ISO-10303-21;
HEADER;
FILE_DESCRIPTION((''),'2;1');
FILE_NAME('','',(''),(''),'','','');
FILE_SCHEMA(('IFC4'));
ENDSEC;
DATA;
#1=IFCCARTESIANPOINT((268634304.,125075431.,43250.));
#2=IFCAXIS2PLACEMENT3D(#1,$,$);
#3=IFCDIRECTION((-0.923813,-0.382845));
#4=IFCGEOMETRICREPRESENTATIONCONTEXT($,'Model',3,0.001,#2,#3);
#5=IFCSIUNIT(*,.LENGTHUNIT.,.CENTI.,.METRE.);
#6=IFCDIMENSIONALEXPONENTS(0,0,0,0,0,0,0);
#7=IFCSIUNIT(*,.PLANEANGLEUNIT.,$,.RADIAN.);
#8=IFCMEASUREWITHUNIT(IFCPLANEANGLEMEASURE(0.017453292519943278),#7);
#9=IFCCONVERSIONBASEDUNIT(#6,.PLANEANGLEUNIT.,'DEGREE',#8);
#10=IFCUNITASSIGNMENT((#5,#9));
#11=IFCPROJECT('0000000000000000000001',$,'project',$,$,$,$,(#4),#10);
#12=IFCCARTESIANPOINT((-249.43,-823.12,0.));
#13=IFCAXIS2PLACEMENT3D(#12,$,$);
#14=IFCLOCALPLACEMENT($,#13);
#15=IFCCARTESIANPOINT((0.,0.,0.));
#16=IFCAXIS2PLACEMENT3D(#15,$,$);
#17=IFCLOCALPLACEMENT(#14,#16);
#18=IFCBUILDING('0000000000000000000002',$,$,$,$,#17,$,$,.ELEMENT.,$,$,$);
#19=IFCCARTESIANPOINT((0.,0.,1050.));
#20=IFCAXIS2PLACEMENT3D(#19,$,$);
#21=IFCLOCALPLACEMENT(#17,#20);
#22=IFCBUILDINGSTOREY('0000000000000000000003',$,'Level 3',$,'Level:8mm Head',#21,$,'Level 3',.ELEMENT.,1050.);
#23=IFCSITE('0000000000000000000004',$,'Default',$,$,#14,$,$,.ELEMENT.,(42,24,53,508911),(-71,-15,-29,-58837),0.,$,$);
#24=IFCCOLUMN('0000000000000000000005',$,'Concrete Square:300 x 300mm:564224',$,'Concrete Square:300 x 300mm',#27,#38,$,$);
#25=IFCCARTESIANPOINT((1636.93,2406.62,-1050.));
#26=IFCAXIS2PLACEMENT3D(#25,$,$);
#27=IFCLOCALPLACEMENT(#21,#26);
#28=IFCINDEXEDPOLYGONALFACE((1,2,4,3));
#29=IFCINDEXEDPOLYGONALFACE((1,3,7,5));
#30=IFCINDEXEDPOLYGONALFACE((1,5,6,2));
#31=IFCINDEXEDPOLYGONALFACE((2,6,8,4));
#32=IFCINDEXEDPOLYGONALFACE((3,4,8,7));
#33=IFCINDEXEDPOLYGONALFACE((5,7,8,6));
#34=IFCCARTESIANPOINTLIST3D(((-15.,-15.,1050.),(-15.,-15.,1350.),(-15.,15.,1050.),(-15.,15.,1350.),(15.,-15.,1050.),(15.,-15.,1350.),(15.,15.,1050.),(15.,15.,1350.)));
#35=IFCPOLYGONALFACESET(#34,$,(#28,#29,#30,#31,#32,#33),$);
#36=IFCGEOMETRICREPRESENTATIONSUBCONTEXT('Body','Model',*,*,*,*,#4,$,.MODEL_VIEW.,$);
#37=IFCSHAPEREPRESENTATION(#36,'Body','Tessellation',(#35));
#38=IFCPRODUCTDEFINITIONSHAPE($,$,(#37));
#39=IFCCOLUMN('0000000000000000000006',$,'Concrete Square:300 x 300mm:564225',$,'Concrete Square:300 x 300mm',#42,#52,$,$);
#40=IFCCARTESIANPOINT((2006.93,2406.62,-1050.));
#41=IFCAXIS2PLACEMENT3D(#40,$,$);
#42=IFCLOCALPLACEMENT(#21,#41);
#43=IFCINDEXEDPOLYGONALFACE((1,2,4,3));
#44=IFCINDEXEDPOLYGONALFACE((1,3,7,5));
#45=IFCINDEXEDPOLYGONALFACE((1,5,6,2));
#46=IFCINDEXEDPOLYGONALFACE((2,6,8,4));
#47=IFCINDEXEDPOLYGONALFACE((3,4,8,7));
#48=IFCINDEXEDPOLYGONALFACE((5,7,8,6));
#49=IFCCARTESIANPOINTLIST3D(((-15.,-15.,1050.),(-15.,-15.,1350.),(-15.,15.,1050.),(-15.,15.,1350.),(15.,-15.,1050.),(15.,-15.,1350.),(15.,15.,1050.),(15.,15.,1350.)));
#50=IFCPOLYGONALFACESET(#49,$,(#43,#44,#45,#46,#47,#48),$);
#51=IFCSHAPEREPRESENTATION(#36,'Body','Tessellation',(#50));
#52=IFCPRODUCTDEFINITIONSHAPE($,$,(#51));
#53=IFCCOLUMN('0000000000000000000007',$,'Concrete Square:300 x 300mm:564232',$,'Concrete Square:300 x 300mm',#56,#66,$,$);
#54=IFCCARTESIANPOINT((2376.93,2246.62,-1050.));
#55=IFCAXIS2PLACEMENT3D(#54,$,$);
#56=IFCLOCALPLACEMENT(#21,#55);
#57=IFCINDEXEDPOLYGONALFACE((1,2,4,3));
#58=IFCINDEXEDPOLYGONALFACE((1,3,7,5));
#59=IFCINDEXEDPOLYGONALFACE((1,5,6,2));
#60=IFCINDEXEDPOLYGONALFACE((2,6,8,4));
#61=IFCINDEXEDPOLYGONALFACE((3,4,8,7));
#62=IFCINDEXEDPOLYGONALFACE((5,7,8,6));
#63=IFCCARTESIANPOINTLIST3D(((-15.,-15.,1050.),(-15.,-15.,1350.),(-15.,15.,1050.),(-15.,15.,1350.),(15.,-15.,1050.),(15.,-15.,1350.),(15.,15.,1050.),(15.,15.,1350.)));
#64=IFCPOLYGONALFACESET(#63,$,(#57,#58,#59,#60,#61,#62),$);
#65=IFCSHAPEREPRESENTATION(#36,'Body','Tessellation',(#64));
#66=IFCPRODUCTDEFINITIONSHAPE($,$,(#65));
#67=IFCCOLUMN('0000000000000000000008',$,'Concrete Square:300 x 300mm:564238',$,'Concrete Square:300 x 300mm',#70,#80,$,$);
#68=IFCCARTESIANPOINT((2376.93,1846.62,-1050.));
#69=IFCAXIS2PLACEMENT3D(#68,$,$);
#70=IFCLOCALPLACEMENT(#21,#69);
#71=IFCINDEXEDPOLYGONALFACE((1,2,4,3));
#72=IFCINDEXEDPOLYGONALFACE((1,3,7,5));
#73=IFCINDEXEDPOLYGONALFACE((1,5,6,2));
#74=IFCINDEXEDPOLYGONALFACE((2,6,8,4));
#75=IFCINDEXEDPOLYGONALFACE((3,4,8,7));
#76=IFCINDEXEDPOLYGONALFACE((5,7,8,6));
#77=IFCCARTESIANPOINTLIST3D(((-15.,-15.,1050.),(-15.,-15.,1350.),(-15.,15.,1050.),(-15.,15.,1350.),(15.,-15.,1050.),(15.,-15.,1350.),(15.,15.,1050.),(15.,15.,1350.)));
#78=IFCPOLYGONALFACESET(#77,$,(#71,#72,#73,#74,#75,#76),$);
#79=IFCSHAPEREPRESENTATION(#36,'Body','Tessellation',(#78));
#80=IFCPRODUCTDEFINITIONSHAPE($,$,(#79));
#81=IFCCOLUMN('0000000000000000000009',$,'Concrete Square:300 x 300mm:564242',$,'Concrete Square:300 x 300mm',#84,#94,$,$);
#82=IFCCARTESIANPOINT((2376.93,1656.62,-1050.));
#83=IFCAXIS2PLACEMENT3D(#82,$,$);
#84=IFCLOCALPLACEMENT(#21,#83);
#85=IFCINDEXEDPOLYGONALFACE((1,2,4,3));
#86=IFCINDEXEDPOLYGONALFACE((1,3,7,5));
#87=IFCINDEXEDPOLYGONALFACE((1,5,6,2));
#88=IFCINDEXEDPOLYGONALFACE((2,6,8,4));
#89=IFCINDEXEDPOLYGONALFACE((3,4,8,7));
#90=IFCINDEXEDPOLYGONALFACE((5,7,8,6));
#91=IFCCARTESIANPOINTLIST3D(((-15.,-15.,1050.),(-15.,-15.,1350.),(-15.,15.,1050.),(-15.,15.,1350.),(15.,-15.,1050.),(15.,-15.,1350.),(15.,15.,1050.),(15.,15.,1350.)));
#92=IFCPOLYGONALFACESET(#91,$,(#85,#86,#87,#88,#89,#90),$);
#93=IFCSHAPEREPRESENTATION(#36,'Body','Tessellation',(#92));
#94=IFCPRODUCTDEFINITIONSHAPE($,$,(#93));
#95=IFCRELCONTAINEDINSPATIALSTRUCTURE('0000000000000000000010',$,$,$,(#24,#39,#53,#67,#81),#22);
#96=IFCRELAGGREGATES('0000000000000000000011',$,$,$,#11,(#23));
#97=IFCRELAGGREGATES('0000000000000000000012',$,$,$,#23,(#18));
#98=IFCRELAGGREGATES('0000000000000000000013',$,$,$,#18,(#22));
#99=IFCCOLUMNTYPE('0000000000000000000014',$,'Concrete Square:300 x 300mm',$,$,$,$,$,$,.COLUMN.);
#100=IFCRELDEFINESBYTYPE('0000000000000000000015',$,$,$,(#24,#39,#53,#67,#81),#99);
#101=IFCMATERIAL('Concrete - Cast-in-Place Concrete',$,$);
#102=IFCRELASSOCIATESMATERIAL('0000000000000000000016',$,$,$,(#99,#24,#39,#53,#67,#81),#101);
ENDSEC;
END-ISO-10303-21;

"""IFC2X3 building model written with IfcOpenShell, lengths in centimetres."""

from ifc_helpers import new_model, entity, si_unit, converted_unit, direction, frame, origin, origin_2d_with_axis, place, context, subcontext, project, spatial, rectangle, extrude, source, transform, mapped, material, type_object, type_shapes, element, save


model = new_model("IFC2X3")

# Units and contexts
model_context = context("Model", 3, precision=0.001, world=frame((268634304.0, 125075431.0, 43250.0)), true_north=direction((-0.923813, -0.382845)))
body_context = subcontext(model_context, "Body", "Model", "MODEL_VIEW")
ifc_project = project(units=[si_unit("LENGTHUNIT", "METRE", prefix="CENTI"), converted_unit("PLANEANGLEUNIT", "DEGREE", entity("IfcPlaneAngleMeasure", 0.017453292519943278), si_unit("PLANEANGLEUNIT", "RADIAN"), dimensions=[0, 0, 0, 0, 0, 0, 0])], contexts=[model_context])

# Site, building, storey
site_placement = place(None, frame((-249.43, -823.12, 0.0)))
site = spatial("IfcSite", under=ifc_project, at=site_placement, Name="Default", CompositionType="ELEMENT", RefLatitude=(42, 24, 53, 508911), RefLongitude=(-71, -15, -29, -58837), RefElevation=0.0)
building_placement = place(site_placement, origin())
building = spatial("IfcBuilding", under=site, at=building_placement, CompositionType="ELEMENT")
storey_placement = place(building_placement, frame((0.0, 0.0, 1050.0)))
storey = spatial("IfcBuildingStorey", under=building, at=storey_placement, Name="Level 3", ObjectType="Level:8mm Head", LongName="Level 3", CompositionType="ELEMENT", Elevation=1050.0)

# Columns
ifc_material_1 = material(Name="Concrete - Cast-in-Place Concrete")
column_type = type_object("IfcColumnType", Name="Concrete Square:300 x 300mm", PredefinedType="COLUMN", material=ifc_material_1)
shared_shape_1 = source(origin(), body_context, "Body", "SweptSolid", [
    extrude(rectangle(XDim=30.0, YDim=30.0, at=origin_2d_with_axis()), frame((0.0, 0.0, 1050.0), z_axis=(0.0, 0.0, 1.0), x_axis=(-1.0, 0.0, 0.0)), (0.0, 0.0, 1.0), 300.0),
])
type_shapes(column_type, [shared_shape_1])
for number, where, name in (
    (1, (1636.93, 2406.62, -1050.0), "Concrete Square:300 x 300mm:564224"),
    (2, (2006.93, 2406.62, -1050.0), "Concrete Square:300 x 300mm:564225"),
    (3, (2376.93, 2246.62, -1050.0), "Concrete Square:300 x 300mm:564232"),
    (4, (2376.93, 1846.62, -1050.0), "Concrete Square:300 x 300mm:564238"),
    (5, (2376.93, 1656.62, -1050.0), "Concrete Square:300 x 300mm:564242"),
):
    element("IfcColumn", number, at=place(storey_placement, frame(where)), inside=storey, type_object=column_type, material=ifc_material_1, Name=name, ObjectType="Concrete Square:300 x 300mm", context=body_context, shape_type="MappedRepresentation", body=[
        mapped(shared_shape_1, transform((0.0, 0.0, 0.0), scale=1.0)),
    ])

save(model, "model.ifc")
